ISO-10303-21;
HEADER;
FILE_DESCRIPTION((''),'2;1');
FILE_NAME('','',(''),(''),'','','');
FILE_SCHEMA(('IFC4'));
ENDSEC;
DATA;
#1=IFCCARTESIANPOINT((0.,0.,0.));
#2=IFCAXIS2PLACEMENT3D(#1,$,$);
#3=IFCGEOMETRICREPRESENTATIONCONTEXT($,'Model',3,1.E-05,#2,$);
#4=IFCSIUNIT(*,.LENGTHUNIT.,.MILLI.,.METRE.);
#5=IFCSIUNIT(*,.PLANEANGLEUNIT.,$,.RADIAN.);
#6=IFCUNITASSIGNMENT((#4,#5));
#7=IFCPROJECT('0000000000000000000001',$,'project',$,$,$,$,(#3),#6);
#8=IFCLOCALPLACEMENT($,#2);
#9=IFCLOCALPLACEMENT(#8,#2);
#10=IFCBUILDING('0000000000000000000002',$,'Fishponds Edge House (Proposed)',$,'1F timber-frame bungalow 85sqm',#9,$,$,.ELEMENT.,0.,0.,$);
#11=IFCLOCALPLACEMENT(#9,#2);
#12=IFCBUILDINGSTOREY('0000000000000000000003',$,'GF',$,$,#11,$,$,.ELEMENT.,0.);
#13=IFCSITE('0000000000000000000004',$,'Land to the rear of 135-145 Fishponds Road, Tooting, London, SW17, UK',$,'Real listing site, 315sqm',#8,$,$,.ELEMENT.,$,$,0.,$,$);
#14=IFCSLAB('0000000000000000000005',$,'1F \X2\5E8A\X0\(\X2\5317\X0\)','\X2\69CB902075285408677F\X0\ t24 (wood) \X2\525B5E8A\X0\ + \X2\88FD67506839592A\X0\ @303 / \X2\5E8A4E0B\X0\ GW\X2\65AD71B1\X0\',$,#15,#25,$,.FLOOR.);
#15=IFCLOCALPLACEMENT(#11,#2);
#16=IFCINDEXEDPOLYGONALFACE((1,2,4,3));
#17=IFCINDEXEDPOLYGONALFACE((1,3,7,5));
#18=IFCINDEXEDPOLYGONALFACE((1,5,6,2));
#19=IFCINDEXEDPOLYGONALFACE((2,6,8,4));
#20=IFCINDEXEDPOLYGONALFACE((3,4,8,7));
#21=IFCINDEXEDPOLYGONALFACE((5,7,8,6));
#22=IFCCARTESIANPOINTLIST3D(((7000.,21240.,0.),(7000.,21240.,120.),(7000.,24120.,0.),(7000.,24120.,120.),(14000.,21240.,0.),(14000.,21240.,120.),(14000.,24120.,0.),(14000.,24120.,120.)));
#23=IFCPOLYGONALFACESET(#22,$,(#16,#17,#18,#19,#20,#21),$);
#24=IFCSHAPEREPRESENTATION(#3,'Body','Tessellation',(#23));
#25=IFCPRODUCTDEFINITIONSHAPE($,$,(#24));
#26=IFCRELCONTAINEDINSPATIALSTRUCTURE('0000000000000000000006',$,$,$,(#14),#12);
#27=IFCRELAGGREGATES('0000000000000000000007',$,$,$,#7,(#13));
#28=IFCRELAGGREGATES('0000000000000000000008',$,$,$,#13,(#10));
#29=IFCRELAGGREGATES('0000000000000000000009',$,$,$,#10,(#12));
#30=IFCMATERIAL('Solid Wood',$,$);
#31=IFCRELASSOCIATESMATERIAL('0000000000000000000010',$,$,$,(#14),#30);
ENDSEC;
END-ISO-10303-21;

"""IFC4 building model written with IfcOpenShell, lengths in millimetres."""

from ifc_helpers import new_model, si_unit, frame, frame_2d, origin, place, context, project, spatial, rectangle, extrude, material, element, save


model = new_model("IFC4")

# Units and contexts
model_context = context("Model", 3, precision=1e-05, world=origin())
ifc_project = project(units=[si_unit("LENGTHUNIT", "METRE", prefix="MILLI"), si_unit("PLANEANGLEUNIT", "RADIAN")], contexts=[model_context])

# Site, building, storey
site_placement = place(None, origin())
site = spatial("IfcSite", under=ifc_project, at=site_placement, Name="Land to the rear of 135-145 Fishponds Road, Tooting, London, SW17, UK", ObjectType="Real listing site, 315sqm", CompositionType="ELEMENT", RefElevation=0.0)
building_placement = place(site_placement, origin())
building = spatial("IfcBuilding", under=site, at=building_placement, Name="Fishponds Edge House (Proposed)", ObjectType="1F timber-frame bungalow 85sqm", CompositionType="ELEMENT", ElevationOfRefHeight=0.0, ElevationOfTerrain=0.0)
storey_placement = place(building_placement, origin())
storey = spatial("IfcBuildingStorey", under=building, at=storey_placement, Name="GF", CompositionType="ELEMENT", Elevation=0.0)

# Slab
ifc_material_1 = material(Name="Solid Wood")
slab_1_placement = place(storey_placement, frame((3500.0, 10620.0, 0.0)))
element("IfcSlab", 1, at=slab_1_placement, inside=storey, material=ifc_material_1, Name="1F 床(北)", Description="構造用合板 t24 (wood) 剛床 + 製材根太 @303 / 床下 GW断熱", PredefinedType="FLOOR", context=model_context, shape_type="SweptSolid", body=[
    extrude(rectangle(XDim=7000.0, YDim=2880.0, at=frame_2d((3500.0, 1440.0))), frame((3500.0, 10620.0, 0.0)), (0.0, 0.0, 1.0), 120.0),
])

save(model, "model.ifc")
